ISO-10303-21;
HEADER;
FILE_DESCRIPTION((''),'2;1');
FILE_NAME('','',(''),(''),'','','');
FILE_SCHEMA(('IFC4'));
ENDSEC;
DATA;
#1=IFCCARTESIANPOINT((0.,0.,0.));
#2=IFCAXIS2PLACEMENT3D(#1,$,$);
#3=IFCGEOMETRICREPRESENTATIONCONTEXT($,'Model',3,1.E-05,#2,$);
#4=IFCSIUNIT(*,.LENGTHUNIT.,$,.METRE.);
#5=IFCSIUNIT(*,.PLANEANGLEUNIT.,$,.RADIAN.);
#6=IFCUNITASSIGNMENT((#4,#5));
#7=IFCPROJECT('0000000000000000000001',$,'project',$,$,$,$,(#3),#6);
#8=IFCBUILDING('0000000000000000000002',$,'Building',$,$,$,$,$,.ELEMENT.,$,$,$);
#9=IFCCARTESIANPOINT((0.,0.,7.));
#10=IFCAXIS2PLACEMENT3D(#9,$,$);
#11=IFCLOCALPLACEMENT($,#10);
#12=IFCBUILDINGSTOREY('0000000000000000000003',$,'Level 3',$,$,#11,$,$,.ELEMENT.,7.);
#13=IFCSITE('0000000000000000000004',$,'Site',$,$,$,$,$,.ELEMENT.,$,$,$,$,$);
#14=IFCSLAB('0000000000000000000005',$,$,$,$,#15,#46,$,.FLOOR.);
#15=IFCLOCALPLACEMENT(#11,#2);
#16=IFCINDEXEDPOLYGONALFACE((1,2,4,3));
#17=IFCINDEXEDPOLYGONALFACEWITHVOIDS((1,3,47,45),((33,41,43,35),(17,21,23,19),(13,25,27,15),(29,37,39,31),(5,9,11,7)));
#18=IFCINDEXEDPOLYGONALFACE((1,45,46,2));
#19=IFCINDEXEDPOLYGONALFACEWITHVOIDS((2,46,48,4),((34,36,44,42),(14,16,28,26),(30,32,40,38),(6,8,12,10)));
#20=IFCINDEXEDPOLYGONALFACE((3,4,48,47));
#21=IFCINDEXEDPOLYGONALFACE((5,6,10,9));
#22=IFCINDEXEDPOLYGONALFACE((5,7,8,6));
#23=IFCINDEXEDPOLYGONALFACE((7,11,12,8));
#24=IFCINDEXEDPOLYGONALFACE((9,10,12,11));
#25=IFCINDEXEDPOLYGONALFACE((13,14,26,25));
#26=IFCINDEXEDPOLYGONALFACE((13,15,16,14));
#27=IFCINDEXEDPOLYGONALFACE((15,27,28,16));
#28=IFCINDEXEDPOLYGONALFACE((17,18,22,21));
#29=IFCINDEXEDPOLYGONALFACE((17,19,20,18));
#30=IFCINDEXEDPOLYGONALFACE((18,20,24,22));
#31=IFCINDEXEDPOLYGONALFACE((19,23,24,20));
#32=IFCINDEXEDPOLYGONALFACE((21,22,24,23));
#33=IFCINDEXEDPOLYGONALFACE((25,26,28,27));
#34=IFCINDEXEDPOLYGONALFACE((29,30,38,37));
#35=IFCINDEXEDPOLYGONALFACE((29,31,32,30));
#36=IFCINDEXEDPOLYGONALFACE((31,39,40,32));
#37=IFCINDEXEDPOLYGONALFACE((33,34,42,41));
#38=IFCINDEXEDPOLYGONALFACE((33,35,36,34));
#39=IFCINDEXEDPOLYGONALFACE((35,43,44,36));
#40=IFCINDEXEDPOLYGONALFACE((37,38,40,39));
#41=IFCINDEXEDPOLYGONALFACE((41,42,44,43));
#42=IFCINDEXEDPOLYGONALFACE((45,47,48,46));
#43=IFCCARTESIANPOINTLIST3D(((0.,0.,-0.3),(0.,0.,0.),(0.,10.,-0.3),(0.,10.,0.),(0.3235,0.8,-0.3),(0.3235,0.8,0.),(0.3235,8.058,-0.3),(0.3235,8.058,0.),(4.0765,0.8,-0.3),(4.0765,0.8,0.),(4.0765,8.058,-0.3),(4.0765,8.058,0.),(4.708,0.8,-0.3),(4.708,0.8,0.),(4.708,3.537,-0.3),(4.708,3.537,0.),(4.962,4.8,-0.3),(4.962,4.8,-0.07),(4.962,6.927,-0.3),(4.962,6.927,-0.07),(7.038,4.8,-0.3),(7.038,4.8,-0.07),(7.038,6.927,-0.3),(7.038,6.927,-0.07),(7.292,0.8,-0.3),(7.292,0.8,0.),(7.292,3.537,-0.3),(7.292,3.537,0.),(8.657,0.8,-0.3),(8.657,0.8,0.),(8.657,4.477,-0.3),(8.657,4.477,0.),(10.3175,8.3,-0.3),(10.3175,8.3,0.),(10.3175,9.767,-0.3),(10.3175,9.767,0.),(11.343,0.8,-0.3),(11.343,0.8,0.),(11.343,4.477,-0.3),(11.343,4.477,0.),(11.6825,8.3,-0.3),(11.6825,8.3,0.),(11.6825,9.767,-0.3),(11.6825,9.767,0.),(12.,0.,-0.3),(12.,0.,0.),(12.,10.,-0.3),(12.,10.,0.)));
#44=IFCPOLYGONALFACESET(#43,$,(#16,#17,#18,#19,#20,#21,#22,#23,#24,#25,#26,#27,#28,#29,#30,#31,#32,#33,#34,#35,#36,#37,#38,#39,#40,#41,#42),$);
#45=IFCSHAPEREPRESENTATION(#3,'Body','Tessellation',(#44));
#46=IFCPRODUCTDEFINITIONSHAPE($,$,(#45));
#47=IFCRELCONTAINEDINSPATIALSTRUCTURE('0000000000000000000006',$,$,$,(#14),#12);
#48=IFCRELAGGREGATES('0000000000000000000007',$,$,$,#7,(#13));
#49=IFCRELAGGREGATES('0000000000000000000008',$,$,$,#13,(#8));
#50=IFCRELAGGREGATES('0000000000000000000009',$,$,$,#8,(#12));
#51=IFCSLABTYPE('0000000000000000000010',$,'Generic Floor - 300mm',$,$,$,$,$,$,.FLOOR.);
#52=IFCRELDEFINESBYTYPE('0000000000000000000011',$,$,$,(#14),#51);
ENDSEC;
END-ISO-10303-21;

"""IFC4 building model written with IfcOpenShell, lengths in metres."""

from ifc_helpers import new_model, si_unit, frame, origin, place, context, project, spatial, polyline, outline, extrude, type_object, element, save


model = new_model("IFC4")

# Units and contexts
model_context = context("Model", 3, precision=1e-05, world=origin())
ifc_project = project(units=[si_unit("LENGTHUNIT", "METRE"), si_unit("PLANEANGLEUNIT", "RADIAN")], contexts=[model_context])

# Site, building, storey
site = spatial("IfcSite", under=ifc_project, Name="Site", CompositionType="ELEMENT")
building = spatial("IfcBuilding", under=site, Name="Building", CompositionType="ELEMENT")
storey_placement = place(None, frame((0.0, 0.0, 7.0)))
storey = spatial("IfcBuildingStorey", under=building, at=storey_placement, Name="Level 3", CompositionType="ELEMENT", Elevation=7.0)

# Slab, openings
slab_type = type_object("IfcSlabType", Name="Generic Floor - 300mm", PredefinedType="FLOOR")
slab_placement = place(None, frame((0.0, 0.0, 7.0)))
slab = element("IfcSlab", 1, at=slab_placement, inside=storey, type_object=slab_type, PredefinedType="FLOOR", context=model_context, shape_type="SweptSolid", body=[
    extrude(outline(polyline([(0.0, 0.0), (12.0, 0.0), (12.0, 10.0), (0.0, 10.0), (0.0, 0.0)])), origin(), (0.0, 0.0, -1.0), 0.3),
])
opening_1_placement = place(None, frame((0.0, 0.0, 7.001)))
element("IfcOpeningElement", 2, at=opening_1_placement, cuts=slab, PredefinedType="OPENING", context=model_context, shape_type="SweptSolid", body=[
    extrude(outline(polyline([(0.3235, 0.8), (4.0765, 0.8), (4.0765, 8.058), (0.3235, 8.058), (0.3235, 0.8)])), origin(), (0.0, 0.0, -1.0), 0.302),
])
opening_2_placement = place(None, frame((0.0, 0.0, 7.001)))
element("IfcOpeningElement", 3, at=opening_2_placement, cuts=slab, PredefinedType="OPENING", context=model_context, shape_type="SweptSolid", body=[
    extrude(outline(polyline([(4.708, 0.8), (7.292, 0.8), (7.292, 3.537), (4.708, 3.537), (4.708, 0.8)])), origin(), (0.0, 0.0, -1.0), 0.302),
])
opening_3_placement = place(None, frame((0.0, 0.0, 7.001)))
element("IfcOpeningElement", 4, at=opening_3_placement, cuts=slab, PredefinedType="OPENING", context=model_context, shape_type="SweptSolid", body=[
    extrude(outline(polyline([(8.657, 0.8), (11.343, 0.8), (11.343, 4.477), (8.657, 4.477), (8.657, 0.8)])), origin(), (0.0, 0.0, -1.0), 0.302),
])
opening_4_placement = place(None, frame((0.0, 0.0, 6.93)))
element("IfcOpeningElement", 5, at=opening_4_placement, cuts=slab, PredefinedType="OPENING", context=model_context, shape_type="SweptSolid", body=[
    extrude(outline(polyline([(4.962, 4.8), (7.038, 4.8), (7.038, 6.927), (4.962, 6.927), (4.962, 4.8)])), origin(), (0.0, 0.0, -1.0), 0.231),
])
opening_5_placement = place(None, frame((0.0, 0.0, 7.001)))
element("IfcOpeningElement", 6, at=opening_5_placement, cuts=slab, PredefinedType="OPENING", context=model_context, shape_type="SweptSolid", body=[
    extrude(outline(polyline([(10.3175, 8.3), (11.6825, 8.3), (11.6825, 9.767), (10.3175, 9.767), (10.3175, 8.3)])), origin(), (0.0, 0.0, -1.0), 0.302),
])

save(model, "model.ifc")
